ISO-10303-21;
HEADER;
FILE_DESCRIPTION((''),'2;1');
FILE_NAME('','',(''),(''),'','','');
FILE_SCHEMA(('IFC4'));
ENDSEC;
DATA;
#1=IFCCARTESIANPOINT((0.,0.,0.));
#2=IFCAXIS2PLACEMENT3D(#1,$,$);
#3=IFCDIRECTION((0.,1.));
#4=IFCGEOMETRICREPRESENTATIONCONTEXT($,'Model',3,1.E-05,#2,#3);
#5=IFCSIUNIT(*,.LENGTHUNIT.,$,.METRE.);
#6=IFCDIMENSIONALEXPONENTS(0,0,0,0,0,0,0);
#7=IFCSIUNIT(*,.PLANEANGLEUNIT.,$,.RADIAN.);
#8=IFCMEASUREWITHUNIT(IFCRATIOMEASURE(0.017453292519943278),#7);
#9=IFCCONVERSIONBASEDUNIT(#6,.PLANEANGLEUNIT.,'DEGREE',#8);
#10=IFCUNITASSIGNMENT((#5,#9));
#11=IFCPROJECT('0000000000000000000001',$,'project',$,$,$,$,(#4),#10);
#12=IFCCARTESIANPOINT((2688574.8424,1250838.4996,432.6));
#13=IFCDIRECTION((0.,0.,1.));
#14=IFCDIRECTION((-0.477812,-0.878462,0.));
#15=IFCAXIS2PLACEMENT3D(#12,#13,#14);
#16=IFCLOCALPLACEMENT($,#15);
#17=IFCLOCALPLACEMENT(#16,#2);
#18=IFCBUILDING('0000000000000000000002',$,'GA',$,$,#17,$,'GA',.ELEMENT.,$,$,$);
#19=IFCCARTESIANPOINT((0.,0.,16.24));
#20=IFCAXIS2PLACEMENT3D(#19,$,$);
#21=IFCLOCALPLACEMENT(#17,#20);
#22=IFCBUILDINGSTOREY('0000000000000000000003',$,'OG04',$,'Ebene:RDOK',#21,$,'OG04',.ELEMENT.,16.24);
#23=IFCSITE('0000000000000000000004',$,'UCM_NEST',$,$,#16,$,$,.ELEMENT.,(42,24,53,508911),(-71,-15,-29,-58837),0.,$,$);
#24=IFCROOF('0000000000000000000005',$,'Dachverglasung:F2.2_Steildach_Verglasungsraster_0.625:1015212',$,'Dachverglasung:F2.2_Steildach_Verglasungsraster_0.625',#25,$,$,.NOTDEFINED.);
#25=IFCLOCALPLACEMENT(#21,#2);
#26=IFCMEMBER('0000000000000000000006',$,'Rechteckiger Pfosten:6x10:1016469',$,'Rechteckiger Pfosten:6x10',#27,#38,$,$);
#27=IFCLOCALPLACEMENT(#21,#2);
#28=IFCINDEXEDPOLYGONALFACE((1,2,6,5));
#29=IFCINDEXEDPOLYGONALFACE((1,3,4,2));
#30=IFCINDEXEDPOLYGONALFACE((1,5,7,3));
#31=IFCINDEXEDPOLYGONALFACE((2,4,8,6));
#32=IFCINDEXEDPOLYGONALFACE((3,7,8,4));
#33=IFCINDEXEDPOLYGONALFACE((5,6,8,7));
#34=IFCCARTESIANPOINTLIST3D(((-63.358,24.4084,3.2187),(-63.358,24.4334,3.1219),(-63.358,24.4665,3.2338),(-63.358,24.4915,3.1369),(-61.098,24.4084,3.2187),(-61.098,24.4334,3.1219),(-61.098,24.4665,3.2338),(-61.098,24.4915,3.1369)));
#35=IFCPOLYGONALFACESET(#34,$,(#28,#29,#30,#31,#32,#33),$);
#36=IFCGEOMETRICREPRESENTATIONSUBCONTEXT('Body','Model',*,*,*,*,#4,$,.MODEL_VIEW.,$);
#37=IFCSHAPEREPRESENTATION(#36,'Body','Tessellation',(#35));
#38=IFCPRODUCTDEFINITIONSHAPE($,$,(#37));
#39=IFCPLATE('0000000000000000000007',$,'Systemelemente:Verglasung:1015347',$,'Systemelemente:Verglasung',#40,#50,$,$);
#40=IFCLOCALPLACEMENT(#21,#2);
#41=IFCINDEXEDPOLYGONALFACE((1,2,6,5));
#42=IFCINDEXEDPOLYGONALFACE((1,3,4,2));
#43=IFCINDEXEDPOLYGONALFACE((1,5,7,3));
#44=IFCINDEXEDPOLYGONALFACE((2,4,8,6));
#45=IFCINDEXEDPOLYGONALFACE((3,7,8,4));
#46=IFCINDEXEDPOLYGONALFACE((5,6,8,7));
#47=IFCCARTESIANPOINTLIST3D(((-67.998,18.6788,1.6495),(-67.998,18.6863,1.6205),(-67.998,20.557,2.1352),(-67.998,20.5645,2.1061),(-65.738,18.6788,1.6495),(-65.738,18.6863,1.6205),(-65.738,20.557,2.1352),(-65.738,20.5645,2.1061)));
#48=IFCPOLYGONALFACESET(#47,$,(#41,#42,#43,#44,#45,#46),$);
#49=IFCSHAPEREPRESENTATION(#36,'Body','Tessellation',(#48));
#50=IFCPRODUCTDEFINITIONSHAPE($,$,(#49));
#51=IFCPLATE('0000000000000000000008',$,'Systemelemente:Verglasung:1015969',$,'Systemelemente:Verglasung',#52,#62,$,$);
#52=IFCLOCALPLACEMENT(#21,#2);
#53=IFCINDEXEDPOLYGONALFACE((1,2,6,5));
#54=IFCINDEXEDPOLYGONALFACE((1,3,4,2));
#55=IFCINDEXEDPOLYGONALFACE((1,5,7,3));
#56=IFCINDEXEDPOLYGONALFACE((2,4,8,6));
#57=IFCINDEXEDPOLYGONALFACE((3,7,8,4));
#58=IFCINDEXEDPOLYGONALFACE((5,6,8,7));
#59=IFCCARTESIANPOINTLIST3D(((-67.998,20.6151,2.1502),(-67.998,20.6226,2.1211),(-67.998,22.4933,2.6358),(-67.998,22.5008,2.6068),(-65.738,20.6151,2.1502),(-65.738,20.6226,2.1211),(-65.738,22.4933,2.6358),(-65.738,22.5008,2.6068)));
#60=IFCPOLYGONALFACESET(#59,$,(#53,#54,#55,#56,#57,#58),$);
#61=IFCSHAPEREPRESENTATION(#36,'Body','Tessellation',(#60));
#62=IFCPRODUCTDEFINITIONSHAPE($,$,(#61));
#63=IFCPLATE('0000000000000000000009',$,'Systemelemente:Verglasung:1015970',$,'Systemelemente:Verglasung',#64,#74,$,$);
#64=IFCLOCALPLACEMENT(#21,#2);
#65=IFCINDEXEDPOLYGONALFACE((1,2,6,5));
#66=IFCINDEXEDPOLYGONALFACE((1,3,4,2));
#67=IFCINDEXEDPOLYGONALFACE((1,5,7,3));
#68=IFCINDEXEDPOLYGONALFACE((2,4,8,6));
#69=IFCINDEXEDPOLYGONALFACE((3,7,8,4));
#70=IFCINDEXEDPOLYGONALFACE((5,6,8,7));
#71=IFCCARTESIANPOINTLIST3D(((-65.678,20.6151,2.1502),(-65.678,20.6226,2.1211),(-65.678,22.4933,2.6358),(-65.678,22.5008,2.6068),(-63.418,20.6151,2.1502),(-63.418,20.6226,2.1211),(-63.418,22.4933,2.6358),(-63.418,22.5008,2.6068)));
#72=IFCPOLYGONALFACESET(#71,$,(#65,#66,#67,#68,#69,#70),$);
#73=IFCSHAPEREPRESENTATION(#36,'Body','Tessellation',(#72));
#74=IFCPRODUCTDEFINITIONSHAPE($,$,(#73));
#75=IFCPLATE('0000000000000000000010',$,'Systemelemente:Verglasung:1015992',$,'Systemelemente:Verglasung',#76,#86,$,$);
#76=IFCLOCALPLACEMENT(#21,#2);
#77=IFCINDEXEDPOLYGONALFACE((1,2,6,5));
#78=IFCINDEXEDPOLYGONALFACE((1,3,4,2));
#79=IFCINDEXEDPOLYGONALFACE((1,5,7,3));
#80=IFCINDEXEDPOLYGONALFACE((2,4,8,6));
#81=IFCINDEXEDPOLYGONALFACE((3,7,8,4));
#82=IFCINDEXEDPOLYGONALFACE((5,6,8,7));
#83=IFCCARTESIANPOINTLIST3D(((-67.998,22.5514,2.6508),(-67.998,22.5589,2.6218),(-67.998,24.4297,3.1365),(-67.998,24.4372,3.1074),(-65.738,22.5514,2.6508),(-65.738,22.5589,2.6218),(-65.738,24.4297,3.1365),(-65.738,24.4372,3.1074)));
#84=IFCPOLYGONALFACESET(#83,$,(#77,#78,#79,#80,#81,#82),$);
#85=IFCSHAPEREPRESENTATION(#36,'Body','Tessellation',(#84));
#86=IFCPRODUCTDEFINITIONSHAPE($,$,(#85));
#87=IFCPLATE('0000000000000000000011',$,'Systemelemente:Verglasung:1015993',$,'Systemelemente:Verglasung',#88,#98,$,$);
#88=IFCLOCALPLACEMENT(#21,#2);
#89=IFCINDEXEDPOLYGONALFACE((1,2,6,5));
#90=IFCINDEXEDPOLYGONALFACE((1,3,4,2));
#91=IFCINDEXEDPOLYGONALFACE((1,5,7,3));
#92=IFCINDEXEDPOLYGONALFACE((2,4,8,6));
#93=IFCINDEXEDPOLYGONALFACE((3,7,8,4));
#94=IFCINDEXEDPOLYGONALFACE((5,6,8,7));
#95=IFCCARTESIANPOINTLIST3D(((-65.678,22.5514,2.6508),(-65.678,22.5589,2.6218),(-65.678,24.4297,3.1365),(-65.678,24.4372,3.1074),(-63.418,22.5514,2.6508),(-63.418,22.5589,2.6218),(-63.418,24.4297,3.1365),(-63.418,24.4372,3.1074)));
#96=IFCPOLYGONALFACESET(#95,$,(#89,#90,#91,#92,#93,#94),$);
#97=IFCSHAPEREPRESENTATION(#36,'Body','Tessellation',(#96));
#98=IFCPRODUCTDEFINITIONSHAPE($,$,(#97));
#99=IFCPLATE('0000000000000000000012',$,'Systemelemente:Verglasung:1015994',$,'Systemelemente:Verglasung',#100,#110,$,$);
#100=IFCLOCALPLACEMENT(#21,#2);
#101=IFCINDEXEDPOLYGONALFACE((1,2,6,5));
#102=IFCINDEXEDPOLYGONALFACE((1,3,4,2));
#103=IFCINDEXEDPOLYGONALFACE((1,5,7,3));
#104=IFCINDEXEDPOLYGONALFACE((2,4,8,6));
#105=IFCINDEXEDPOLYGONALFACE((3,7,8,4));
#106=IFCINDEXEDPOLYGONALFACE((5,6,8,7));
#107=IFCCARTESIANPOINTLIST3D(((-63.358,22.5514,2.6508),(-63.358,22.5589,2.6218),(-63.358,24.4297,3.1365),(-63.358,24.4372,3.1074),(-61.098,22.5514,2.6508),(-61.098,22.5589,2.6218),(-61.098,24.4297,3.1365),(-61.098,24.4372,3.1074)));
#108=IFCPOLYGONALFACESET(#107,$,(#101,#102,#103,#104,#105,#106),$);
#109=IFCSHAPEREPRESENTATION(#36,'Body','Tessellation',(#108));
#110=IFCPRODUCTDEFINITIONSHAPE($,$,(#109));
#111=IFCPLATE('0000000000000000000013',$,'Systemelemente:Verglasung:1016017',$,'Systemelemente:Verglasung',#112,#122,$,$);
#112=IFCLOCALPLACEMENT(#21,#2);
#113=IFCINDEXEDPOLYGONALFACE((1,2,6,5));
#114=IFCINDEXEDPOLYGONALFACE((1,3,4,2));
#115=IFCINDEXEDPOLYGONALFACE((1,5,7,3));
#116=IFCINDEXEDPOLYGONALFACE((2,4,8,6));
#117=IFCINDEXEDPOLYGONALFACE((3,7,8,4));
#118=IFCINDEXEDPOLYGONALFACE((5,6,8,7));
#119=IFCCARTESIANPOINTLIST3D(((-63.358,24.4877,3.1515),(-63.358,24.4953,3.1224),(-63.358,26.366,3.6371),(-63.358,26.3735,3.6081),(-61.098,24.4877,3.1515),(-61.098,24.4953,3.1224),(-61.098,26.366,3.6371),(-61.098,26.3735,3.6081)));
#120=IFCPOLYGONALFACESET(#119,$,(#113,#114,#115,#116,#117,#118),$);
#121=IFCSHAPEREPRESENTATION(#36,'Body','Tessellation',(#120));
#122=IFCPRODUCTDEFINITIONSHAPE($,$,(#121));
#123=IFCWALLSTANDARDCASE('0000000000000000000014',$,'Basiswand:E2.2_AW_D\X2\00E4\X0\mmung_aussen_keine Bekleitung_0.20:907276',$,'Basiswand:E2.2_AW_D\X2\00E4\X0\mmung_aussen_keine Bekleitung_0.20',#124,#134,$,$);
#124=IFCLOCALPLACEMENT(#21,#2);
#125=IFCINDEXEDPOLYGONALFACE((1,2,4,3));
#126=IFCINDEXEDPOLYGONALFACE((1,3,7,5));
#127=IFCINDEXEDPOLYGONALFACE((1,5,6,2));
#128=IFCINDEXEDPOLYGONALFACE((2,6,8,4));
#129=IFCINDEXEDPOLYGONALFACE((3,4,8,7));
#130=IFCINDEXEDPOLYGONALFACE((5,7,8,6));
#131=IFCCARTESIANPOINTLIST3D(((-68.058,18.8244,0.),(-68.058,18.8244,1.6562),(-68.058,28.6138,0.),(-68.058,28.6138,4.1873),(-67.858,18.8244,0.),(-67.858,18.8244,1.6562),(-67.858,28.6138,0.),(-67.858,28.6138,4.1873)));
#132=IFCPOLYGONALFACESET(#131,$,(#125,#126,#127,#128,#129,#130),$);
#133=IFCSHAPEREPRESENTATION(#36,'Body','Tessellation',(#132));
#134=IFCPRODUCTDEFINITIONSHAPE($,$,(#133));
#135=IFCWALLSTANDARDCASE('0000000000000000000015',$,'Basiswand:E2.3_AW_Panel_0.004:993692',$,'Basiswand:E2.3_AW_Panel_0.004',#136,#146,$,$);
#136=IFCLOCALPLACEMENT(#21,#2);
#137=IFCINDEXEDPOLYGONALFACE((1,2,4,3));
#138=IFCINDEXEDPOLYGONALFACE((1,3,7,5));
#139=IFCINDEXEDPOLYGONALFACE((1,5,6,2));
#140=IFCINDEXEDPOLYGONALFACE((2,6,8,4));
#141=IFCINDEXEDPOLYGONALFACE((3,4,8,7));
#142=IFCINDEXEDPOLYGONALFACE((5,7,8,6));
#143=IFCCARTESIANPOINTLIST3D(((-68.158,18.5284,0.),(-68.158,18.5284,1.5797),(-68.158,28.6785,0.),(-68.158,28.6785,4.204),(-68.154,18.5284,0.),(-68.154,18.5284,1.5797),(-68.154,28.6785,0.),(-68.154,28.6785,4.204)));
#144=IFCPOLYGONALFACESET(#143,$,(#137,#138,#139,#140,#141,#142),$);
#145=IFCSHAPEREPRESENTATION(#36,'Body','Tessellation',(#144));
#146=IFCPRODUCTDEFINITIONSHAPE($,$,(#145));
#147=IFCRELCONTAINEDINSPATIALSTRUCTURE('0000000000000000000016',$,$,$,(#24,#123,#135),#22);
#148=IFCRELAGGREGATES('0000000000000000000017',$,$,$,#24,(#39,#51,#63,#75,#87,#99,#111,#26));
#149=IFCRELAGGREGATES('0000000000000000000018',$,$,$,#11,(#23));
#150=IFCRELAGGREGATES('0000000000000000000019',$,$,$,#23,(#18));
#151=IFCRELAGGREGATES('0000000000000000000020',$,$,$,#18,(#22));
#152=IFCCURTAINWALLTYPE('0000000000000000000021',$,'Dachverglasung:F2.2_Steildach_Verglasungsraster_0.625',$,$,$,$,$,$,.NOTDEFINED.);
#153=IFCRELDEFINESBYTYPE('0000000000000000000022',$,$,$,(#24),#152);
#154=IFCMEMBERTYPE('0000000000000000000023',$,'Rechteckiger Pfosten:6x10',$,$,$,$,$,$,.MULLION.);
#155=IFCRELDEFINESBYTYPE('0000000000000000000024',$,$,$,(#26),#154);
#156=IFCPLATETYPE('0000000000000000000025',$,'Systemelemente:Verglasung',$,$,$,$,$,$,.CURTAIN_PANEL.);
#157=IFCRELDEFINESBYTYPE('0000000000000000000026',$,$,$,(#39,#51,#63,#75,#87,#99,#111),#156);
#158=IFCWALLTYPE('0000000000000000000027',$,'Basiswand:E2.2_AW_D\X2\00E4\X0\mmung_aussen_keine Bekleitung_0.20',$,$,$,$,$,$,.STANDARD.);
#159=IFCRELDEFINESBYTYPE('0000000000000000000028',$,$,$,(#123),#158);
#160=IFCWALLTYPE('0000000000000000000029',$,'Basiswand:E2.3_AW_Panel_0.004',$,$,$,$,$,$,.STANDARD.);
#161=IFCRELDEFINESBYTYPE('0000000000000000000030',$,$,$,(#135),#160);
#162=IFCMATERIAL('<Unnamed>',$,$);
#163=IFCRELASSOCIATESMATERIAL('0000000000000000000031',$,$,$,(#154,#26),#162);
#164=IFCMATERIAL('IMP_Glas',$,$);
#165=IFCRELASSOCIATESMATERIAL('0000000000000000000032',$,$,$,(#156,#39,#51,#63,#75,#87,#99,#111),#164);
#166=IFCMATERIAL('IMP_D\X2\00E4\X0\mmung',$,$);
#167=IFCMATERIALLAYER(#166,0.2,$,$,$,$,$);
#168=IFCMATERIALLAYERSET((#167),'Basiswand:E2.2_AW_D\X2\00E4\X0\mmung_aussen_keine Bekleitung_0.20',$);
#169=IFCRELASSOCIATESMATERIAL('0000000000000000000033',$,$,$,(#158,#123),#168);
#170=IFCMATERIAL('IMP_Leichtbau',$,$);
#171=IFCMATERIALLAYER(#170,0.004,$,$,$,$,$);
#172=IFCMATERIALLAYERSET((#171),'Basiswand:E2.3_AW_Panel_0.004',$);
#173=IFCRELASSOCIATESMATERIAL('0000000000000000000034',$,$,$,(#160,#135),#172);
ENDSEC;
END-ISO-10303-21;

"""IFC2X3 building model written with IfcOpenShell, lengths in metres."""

from ifc_helpers import new_model, entity, si_unit, converted_unit, direction, frame, frame_2d, origin, origin_2d_with_axis, place, context, subcontext, project, spatial, rectangle, extrude, clip, halfspace, source, transform, mapped, material, layer, layer_set, layer_usage, type_object, type_shapes, element, aggregate, save


model = new_model("IFC2X3")

# Units and contexts
model_context = context("Model", 3, precision=1e-05, world=origin(), true_north=direction((0.0, 1.0)))
body_context = subcontext(model_context, "Body", "Model", "MODEL_VIEW")
ifc_project = project(units=[si_unit("LENGTHUNIT", "METRE"), converted_unit("PLANEANGLEUNIT", "DEGREE", entity("IfcRatioMeasure", 0.017453292519943278), si_unit("PLANEANGLEUNIT", "RADIAN"), dimensions=[0, 0, 0, 0, 0, 0, 0])], contexts=[model_context])

# Site, building, storey
site_placement = place(None, frame((2688574.8424, 1250838.4996, 432.6), z_axis=(0.0, 0.0, 1.0), x_axis=(-0.477812, -0.878462, 0.0)))
site = spatial("IfcSite", under=ifc_project, at=site_placement, Name="UCM_NEST", CompositionType="ELEMENT", RefLatitude=(42, 24, 53, 508911), RefLongitude=(-71, -15, -29, -58837), RefElevation=0.0)
building_placement = place(site_placement, origin())
building = spatial("IfcBuilding", under=site, at=building_placement, Name="GA", LongName="GA", CompositionType="ELEMENT")
storey_placement = place(building_placement, frame((0.0, 0.0, 16.24)))
storey = spatial("IfcBuildingStorey", under=building, at=storey_placement, Name="OG04", ObjectType="Ebene:RDOK", LongName="OG04", CompositionType="ELEMENT", Elevation=16.24)

# Roof, member, plates
curtain_wall_type = type_object("IfcCurtainWallType", Name="Dachverglasung:F2.2_Steildach_Verglasungsraster_0.625", PredefinedType="NOTDEFINED")
roof_placement = place(storey_placement, frame((0.0, 0.0, -16.24)))
roof = element("IfcRoof", 1, at=roof_placement, inside=storey, type_object=curtain_wall_type, Name="Dachverglasung:F2.2_Steildach_Verglasungsraster_0.625:1015212", ObjectType="Dachverglasung:F2.2_Steildach_Verglasungsraster_0.625", ShapeType="NOTDEFINED")
ifc_material_1 = material(Name="<Unnamed>")
member_type_1 = type_object("IfcMemberType", Name="Rechteckiger Pfosten:6x10", PredefinedType="MULLION", material=ifc_material_1)
shared_shape_1 = source(origin(), body_context, "Body", "SweptSolid", [
    extrude(rectangle(XDim=0.1, YDim=0.06, at=origin_2d_with_axis()), frame((-0.03, -0.05, -2.26), z_axis=(0.0, 0.0, 1.0), x_axis=(0.0, -1.0, 0.0)), (0.0, 0.0, 1.0), 2.26),
])
type_shapes(member_type_1, [shared_shape_1])
member_1_placement = place(roof_placement, frame((-63.358, 24.4915, 19.3769), z_axis=(-1.0, 0.0, 0.0), x_axis=(0.0, 0.968163, 0.250322)))
member_1 = element("IfcMember", 2, at=member_1_placement, type_object=member_type_1, material=ifc_material_1, Name="Rechteckiger Pfosten:6x10:1016469", ObjectType="Rechteckiger Pfosten:6x10", context=body_context, shape_type="MappedRepresentation", body=[
    mapped(shared_shape_1, transform((0.0, 0.0, 0.0), scale=1.0)),
])
ifc_material_2 = material(Name="IMP_Glas")
plate_type = type_object("IfcPlateType", Name="Systemelemente:Verglasung", PredefinedType="CURTAIN_PANEL", material=ifc_material_2)
shared_shape_2 = source(origin(), body_context, "Body", "SweptSolid", [
    extrude(rectangle(XDim=0.03, YDim=2.26, at=origin_2d_with_axis()), frame((0.0, 0.0, 0.0), z_axis=(0.0, 0.0, 1.0), x_axis=(0.0, 1.0, 0.0)), (0.0, 0.0, 1.0), 1.94),
])
type_shapes(plate_type, [shared_shape_2])
plate_1_placement = place(roof_placement, frame((-66.868, 18.6825, 17.875), z_axis=(0.0, 0.968163, 0.250322), x_axis=(1.0, 0.0, 0.0)))
plate_1 = element("IfcPlate", 3, at=plate_1_placement, type_object=plate_type, material=ifc_material_2, Name="Systemelemente:Verglasung:1015347", ObjectType="Systemelemente:Verglasung", context=body_context, shape_type="MappedRepresentation", body=[
    mapped(shared_shape_2, transform((0.0, 0.0, 0.0), scale=1.0)),
])
plate_2_placement = place(roof_placement, frame((-66.868, 20.6189, 18.3757), z_axis=(0.0, 0.968163, 0.250322), x_axis=(1.0, 0.0, 0.0)))
plate_2 = element("IfcPlate", 4, at=plate_2_placement, type_object=plate_type, material=ifc_material_2, Name="Systemelemente:Verglasung:1015969", ObjectType="Systemelemente:Verglasung", context=body_context, shape_type="MappedRepresentation", body=[
    mapped(shared_shape_2, transform((0.0, 0.0, 0.0), scale=1.0)),
])
plate_3_placement = place(roof_placement, frame((-64.548, 20.6189, 18.3757), z_axis=(0.0, 0.968163, 0.250322), x_axis=(1.0, 0.0, 0.0)))
plate_3 = element("IfcPlate", 5, at=plate_3_placement, type_object=plate_type, material=ifc_material_2, Name="Systemelemente:Verglasung:1015970", ObjectType="Systemelemente:Verglasung", context=body_context, shape_type="MappedRepresentation", body=[
    mapped(shared_shape_2, transform((0.0, 0.0, 0.0), scale=1.0)),
])
plate_4_placement = place(roof_placement, frame((-66.868, 22.5552, 18.8763), z_axis=(0.0, 0.968163, 0.250322), x_axis=(1.0, 0.0, 0.0)))
plate_4 = element("IfcPlate", 6, at=plate_4_placement, type_object=plate_type, material=ifc_material_2, Name="Systemelemente:Verglasung:1015992", ObjectType="Systemelemente:Verglasung", context=body_context, shape_type="MappedRepresentation", body=[
    mapped(shared_shape_2, transform((0.0, 0.0, 0.0), scale=1.0)),
])
plate_5_placement = place(roof_placement, frame((-64.548, 22.5552, 18.8763), z_axis=(0.0, 0.968163, 0.250322), x_axis=(1.0, 0.0, 0.0)))
plate_5 = element("IfcPlate", 7, at=plate_5_placement, type_object=plate_type, material=ifc_material_2, Name="Systemelemente:Verglasung:1015993", ObjectType="Systemelemente:Verglasung", context=body_context, shape_type="MappedRepresentation", body=[
    mapped(shared_shape_2, transform((0.0, 0.0, 0.0), scale=1.0)),
])
plate_6_placement = place(roof_placement, frame((-62.228, 22.5552, 18.8763), z_axis=(0.0, 0.968163, 0.250322), x_axis=(1.0, 0.0, 0.0)))
plate_6 = element("IfcPlate", 8, at=plate_6_placement, type_object=plate_type, material=ifc_material_2, Name="Systemelemente:Verglasung:1015994", ObjectType="Systemelemente:Verglasung", context=body_context, shape_type="MappedRepresentation", body=[
    mapped(shared_shape_2, transform((0.0, 0.0, 0.0), scale=1.0)),
])
plate_7_placement = place(roof_placement, frame((-62.228, 24.4915, 19.3769), z_axis=(0.0, 0.968163, 0.250322), x_axis=(1.0, 0.0, 0.0)))
plate_7 = element("IfcPlate", 9, at=plate_7_placement, type_object=plate_type, material=ifc_material_2, Name="Systemelemente:Verglasung:1016017", ObjectType="Systemelemente:Verglasung", context=body_context, shape_type="MappedRepresentation", body=[
    mapped(shared_shape_2, transform((0.0, 0.0, 0.0), scale=1.0)),
])
aggregate(roof, [plate_1, plate_2, plate_3, plate_4, plate_5, plate_6, plate_7, member_1])

# Wall
ifc_material_3 = material(Name="IMP_Dämmung")
ifc_layer_1 = layer(ifc_material_3, 0.2)
ifc_layer_set_1 = layer_set([ifc_layer_1], Name="Basiswand:E2.2_AW_Dämmung_aussen_keine Bekleitung_0.20")
ifc_layer_usage_1 = layer_usage(ifc_layer_set_1, "AXIS2", "NEGATIVE", 0.1)
wall_type_1 = type_object("IfcWallType", Name="Basiswand:E2.2_AW_Dämmung_aussen_keine Bekleitung_0.20", PredefinedType="STANDARD", material=ifc_layer_set_1)
wall_1_placement = place(storey_placement, frame((-67.958, 18.8244, 0.0), z_axis=(0.0, 0.0, 1.0), x_axis=(0.0, 1.0, 0.0)))
element("IfcWallStandardCase", 10, at=wall_1_placement, inside=storey, type_object=wall_type_1, material=ifc_layer_usage_1, Name="Basiswand:E2.2_AW_Dämmung_aussen_keine Bekleitung_0.20:907276", ObjectType="Basiswand:E2.2_AW_Dämmung_aussen_keine Bekleitung_0.20", context=body_context, shape_type="Clipping", body=[
    clip(extrude(rectangle(XDim=9.7894, YDim=0.2, at=frame_2d((4.8947, 0.0), x_axis=(-1.0, 0.0))), origin(), (0.0, 0.0, 1.0), 4.1873), halfspace(frame((0.0, -0.1, 1.6562), z_axis=(-0.250322, 0.0, 0.968163), x_axis=(0.0, 1.0, 0.0)), False)),
])

# Wall
ifc_material_4 = material(Name="IMP_Leichtbau")
ifc_layer_2 = layer(ifc_material_4, 0.004)
ifc_layer_set_2 = layer_set([ifc_layer_2], Name="Basiswand:E2.3_AW_Panel_0.004")
ifc_layer_usage_2 = layer_usage(ifc_layer_set_2, "AXIS2", "NEGATIVE", 0.002)
wall_type_2 = type_object("IfcWallType", Name="Basiswand:E2.3_AW_Panel_0.004", PredefinedType="STANDARD", material=ifc_layer_set_2)
wall_2_placement = place(storey_placement, frame((-68.156, 18.5284, 0.0), z_axis=(0.0, 0.0, 1.0), x_axis=(0.0, 1.0, 0.0)))
element("IfcWallStandardCase", 11, at=wall_2_placement, inside=storey, type_object=wall_type_2, material=ifc_layer_usage_2, Name="Basiswand:E2.3_AW_Panel_0.004:993692", ObjectType="Basiswand:E2.3_AW_Panel_0.004", context=body_context, shape_type="Clipping", body=[
    clip(extrude(rectangle(XDim=10.1501, YDim=0.004, at=frame_2d((5.075, 0.0), x_axis=(-1.0, 0.0))), origin(), (0.0, 0.0, 1.0), 4.204), halfspace(frame((0.0, -0.002, 1.5797), z_axis=(-0.250322, 0.0, 0.968163), x_axis=(0.0, 1.0, 0.0)), False)),
])

save(model, "model.ifc")
